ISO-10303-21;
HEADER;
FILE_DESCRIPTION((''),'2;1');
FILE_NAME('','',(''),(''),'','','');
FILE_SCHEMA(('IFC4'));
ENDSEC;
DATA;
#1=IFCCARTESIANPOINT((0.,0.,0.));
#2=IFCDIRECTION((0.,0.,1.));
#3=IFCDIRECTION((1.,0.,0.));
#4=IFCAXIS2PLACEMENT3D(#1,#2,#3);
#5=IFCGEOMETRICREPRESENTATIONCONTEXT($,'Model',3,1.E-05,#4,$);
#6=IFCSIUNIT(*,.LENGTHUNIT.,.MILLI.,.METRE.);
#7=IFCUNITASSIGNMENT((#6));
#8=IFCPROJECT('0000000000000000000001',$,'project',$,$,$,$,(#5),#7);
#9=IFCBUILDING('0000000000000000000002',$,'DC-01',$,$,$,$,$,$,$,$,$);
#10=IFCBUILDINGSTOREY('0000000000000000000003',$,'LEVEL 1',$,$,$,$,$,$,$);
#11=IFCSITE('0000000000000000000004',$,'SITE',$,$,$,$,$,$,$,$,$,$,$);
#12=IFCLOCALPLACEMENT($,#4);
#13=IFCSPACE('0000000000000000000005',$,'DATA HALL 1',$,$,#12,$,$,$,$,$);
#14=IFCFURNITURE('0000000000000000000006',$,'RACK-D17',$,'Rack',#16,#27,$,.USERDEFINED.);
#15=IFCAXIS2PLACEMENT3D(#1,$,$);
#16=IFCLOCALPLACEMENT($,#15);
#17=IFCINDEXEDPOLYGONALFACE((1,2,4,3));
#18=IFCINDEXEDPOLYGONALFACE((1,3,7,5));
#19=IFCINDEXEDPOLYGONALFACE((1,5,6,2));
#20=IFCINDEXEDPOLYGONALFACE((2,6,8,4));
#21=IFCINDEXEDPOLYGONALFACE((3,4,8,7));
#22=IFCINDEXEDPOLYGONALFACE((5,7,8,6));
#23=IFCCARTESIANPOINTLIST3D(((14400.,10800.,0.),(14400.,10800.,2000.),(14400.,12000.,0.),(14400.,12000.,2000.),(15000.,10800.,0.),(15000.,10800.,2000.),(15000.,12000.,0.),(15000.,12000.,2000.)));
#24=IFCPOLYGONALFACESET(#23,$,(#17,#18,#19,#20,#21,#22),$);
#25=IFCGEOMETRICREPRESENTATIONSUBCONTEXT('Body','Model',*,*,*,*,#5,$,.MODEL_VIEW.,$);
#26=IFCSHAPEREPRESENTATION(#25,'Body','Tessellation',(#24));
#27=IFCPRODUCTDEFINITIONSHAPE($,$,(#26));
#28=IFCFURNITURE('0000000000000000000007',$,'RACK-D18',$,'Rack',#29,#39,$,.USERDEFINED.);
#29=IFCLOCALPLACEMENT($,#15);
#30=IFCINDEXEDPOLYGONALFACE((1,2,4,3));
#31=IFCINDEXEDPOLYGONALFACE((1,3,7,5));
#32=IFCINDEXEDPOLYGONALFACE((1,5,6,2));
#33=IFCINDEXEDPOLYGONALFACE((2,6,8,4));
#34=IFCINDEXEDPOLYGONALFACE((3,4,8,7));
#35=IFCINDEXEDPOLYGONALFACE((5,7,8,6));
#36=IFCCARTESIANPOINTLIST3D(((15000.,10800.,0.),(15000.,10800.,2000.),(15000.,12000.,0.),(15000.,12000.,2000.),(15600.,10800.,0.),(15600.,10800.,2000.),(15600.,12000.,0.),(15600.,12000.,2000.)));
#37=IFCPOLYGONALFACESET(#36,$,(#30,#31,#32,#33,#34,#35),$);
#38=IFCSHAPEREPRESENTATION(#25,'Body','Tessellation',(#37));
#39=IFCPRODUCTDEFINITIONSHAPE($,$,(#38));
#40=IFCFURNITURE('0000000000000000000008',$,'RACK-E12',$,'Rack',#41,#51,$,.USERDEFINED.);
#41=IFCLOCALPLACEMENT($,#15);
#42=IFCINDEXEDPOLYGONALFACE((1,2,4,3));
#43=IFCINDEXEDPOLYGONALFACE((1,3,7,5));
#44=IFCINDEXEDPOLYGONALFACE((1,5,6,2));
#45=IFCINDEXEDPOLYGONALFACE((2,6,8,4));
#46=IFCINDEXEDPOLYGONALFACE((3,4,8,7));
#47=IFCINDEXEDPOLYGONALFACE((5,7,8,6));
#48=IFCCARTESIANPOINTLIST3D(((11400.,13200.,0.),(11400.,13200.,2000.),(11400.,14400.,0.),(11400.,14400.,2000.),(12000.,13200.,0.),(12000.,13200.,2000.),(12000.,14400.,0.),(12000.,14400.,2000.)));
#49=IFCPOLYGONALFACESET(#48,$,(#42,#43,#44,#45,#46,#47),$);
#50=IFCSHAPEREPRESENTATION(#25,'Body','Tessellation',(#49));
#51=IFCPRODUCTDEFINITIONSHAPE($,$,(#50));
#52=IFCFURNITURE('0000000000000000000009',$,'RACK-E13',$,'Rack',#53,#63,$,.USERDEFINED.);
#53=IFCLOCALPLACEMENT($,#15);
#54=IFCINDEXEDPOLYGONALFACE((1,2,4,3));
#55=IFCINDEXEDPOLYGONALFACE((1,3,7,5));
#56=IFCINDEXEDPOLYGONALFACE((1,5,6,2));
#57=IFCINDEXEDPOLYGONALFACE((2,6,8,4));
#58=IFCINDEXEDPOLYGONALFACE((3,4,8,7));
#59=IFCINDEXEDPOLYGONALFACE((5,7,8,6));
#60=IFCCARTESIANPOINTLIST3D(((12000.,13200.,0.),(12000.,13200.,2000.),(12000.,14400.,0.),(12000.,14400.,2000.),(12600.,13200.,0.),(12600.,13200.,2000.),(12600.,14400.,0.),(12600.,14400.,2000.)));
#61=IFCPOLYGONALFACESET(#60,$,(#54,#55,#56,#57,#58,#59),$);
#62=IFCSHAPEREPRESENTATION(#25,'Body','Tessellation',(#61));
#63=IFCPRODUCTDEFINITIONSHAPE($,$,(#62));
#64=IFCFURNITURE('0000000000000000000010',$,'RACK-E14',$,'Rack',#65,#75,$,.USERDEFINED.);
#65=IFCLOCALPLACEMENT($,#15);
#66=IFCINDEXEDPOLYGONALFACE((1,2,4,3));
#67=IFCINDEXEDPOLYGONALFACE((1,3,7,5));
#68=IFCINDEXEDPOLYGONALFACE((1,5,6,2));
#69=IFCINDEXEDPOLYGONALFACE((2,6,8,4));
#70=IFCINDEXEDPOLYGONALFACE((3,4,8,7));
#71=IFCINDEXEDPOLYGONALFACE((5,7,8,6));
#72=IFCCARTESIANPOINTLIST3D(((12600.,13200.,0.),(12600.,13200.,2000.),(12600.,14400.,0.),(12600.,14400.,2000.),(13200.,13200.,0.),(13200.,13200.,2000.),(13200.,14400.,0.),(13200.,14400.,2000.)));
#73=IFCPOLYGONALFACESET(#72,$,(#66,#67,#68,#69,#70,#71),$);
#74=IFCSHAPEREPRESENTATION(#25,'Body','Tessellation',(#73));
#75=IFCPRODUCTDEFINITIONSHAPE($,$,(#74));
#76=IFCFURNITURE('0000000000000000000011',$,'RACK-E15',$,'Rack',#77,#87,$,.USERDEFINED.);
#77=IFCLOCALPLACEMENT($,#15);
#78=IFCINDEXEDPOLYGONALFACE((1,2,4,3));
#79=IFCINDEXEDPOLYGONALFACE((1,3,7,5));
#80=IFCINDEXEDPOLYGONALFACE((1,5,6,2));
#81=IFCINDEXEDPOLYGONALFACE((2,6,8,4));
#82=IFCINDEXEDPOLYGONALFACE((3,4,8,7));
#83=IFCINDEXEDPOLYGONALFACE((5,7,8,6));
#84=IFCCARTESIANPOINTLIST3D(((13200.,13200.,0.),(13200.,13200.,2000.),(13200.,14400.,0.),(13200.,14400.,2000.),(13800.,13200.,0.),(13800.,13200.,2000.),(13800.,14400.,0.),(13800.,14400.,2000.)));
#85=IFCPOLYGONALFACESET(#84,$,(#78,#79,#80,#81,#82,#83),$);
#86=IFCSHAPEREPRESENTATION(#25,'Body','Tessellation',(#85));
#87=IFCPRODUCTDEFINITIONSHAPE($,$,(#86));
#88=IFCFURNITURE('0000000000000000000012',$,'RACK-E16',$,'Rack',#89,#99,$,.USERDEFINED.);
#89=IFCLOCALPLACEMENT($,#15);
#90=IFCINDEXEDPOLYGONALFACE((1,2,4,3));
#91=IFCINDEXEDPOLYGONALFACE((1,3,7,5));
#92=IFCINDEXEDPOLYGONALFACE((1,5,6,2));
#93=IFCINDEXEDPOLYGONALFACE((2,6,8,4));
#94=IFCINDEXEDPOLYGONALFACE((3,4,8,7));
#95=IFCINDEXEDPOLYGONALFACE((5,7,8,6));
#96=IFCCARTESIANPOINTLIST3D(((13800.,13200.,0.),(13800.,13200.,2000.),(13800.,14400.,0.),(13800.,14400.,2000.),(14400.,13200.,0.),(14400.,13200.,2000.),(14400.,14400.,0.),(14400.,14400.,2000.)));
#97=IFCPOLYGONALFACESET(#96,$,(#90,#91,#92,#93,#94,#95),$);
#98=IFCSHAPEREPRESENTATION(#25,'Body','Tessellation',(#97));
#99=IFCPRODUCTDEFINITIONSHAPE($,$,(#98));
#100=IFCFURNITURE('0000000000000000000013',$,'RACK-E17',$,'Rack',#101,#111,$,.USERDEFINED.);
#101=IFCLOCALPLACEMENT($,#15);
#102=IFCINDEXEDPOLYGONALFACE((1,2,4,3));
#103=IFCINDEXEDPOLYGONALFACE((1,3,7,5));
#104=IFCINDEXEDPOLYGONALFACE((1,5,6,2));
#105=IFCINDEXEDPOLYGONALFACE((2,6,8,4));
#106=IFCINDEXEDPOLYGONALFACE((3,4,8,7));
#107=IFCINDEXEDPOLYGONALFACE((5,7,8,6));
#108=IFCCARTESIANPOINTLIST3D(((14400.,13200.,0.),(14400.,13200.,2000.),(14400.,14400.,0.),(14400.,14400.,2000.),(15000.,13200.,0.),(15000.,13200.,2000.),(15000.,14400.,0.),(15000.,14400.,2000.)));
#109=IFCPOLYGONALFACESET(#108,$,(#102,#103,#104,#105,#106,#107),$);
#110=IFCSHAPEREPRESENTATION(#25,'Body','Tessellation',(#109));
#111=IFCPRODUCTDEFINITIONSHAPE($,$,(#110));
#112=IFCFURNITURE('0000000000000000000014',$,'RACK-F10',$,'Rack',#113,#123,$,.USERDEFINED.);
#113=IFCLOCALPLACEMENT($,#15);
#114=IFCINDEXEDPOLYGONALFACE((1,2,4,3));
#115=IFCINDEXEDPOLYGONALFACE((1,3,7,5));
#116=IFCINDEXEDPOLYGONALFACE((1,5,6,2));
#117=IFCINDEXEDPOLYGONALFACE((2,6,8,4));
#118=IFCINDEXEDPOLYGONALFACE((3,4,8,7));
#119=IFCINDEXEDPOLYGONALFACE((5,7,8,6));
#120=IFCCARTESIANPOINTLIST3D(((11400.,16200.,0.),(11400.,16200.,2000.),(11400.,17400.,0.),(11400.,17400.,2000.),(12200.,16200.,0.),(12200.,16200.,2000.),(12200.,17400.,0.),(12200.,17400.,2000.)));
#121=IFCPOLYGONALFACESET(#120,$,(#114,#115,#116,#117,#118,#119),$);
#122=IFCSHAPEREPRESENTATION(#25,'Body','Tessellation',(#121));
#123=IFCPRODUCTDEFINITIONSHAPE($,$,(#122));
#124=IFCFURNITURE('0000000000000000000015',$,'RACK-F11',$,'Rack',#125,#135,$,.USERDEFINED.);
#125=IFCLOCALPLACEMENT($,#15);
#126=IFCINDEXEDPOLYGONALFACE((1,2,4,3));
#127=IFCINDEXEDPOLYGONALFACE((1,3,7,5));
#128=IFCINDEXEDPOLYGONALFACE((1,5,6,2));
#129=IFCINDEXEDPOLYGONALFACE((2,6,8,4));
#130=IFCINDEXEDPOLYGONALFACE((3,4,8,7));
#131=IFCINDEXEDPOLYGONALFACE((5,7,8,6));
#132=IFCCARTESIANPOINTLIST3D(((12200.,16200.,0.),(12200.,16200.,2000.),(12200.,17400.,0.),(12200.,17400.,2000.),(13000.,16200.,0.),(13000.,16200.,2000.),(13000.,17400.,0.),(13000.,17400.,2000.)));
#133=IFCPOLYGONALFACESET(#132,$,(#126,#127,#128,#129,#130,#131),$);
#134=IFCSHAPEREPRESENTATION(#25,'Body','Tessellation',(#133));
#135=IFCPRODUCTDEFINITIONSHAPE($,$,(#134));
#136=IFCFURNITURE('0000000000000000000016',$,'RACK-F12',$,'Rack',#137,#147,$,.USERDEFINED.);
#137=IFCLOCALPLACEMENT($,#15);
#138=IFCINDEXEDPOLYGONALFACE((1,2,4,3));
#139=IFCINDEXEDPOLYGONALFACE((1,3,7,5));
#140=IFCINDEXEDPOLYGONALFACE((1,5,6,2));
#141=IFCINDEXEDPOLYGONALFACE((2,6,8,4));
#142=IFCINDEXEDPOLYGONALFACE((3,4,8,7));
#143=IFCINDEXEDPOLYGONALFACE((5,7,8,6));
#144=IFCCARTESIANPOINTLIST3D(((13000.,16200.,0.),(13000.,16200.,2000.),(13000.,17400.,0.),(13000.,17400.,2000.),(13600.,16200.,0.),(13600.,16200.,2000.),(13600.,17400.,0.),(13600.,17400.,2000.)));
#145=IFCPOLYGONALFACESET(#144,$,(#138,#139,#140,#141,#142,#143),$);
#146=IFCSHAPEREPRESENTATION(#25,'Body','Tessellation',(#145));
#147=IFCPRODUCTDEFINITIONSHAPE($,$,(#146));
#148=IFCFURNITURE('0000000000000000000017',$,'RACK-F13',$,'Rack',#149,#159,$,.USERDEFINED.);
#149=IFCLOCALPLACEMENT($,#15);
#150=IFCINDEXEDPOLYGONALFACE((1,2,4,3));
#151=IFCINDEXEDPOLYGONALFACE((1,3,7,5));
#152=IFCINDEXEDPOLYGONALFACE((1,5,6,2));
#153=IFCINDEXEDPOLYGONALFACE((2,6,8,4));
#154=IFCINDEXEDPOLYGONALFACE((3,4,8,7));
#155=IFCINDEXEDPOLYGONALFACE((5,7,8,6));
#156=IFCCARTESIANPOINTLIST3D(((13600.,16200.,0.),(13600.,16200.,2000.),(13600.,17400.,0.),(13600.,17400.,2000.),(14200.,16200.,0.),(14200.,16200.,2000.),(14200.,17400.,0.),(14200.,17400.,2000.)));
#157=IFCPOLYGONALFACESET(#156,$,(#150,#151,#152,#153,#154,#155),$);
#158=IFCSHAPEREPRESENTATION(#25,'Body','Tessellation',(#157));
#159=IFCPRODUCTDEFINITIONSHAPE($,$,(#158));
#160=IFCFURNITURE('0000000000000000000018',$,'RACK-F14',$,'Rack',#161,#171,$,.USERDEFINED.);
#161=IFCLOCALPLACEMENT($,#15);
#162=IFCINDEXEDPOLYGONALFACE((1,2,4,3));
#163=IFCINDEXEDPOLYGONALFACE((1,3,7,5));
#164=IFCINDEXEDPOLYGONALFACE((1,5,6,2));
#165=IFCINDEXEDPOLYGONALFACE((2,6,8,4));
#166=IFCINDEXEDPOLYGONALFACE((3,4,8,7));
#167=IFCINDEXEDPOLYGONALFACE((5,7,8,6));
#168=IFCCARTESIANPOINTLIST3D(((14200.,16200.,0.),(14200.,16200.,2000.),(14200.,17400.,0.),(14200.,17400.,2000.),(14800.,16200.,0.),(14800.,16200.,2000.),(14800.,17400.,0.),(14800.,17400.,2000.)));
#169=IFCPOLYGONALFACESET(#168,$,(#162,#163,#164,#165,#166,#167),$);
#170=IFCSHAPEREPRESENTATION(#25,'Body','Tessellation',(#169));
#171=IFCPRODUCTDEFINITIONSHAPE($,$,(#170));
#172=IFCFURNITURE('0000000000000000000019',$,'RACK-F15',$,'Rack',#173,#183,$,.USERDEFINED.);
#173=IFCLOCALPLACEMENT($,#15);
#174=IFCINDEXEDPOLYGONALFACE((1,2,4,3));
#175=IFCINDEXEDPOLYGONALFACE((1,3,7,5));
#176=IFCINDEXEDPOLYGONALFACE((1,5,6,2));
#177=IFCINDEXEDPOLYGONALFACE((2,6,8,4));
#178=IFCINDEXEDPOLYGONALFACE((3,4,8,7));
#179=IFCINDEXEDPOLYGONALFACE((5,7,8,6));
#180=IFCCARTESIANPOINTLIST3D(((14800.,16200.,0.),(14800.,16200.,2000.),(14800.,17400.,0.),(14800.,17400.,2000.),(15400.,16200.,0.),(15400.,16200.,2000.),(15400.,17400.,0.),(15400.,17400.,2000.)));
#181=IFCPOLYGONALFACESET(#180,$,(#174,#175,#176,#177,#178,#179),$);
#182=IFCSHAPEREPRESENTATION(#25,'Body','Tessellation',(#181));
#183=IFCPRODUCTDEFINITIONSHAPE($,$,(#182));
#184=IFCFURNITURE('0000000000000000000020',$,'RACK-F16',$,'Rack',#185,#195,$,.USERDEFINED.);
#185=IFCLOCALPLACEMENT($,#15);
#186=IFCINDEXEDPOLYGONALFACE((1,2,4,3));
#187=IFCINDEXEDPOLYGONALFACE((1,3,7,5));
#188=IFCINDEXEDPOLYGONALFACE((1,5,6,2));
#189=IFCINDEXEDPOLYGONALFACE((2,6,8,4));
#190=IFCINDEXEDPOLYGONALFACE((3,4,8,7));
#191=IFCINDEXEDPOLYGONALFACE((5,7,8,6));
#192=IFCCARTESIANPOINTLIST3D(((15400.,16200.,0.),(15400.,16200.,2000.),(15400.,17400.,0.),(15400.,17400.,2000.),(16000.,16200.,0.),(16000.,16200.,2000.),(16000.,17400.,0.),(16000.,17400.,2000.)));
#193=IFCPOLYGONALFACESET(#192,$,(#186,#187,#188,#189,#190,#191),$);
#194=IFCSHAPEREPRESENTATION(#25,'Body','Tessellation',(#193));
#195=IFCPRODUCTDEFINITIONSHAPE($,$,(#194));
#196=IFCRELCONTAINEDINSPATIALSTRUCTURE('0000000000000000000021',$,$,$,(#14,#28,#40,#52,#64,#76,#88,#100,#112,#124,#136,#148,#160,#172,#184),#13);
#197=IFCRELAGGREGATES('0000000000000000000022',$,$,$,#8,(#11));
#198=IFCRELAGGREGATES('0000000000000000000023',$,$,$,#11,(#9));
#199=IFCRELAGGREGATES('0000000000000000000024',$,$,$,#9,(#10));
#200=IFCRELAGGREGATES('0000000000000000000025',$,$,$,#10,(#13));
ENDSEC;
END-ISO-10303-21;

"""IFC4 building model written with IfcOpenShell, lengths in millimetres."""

from ifc_helpers import new_model, si_unit, frame, origin, origin_with_axes, place, context, subcontext, project, spatial, polyline, outline, extrude, element, save


model = new_model("IFC4")

# Units and contexts
model_context = context("Model", 3, precision=1e-05, world=origin_with_axes())
body_context = subcontext(model_context, "Body", "Model", "MODEL_VIEW")
ifc_project = project(units=[si_unit("LENGTHUNIT", "METRE", prefix="MILLI")], contexts=[model_context])

# Site, building, storey, space
site = spatial("IfcSite", under=ifc_project, Name="SITE")
building = spatial("IfcBuilding", under=site, Name="DC-01")
storey = spatial("IfcBuildingStorey", under=building, Name="LEVEL 1")
space_placement = place(None, origin_with_axes())
space = spatial("IfcSpace", under=storey, at=space_placement, Name="DATA HALL 1")

# Furniture
for number, where, z_axis, x_axis, name in (
    (1, (14400.0, 10800.0, 0.0), (0.0, 0.0, 1.0), (1.0, 0.0, 0.0), "RACK-D17"),
    (2, (15000.0, 10800.0, 0.0), (0.0, 0.0, 1.0), (1.0, 0.0, 0.0), "RACK-D18"),
    (3, (12000.0, 14400.0, 0.0), (0.0, 0.0, 1.0), (-1.0, 0.0, 0.0), "RACK-E12"),
    (4, (12600.0, 14400.0, 0.0), (0.0, 0.0, 1.0), (-1.0, 0.0, 0.0), "RACK-E13"),
    (5, (13200.0, 14400.0, 0.0), (0.0, 0.0, 1.0), (-1.0, 0.0, 0.0), "RACK-E14"),
    (6, (13800.0, 14400.0, 0.0), (0.0, 0.0, 1.0), (-1.0, 0.0, 0.0), "RACK-E15"),
    (7, (14400.0, 14400.0, 0.0), (0.0, 0.0, 1.0), (-1.0, 0.0, 0.0), "RACK-E16"),
    (8, (15000.0, 14400.0, 0.0), (0.0, 0.0, 1.0), (-1.0, 0.0, 0.0), "RACK-E17"),
):
    element("IfcFurniture", number, at=place(space_placement, frame(where, z_axis=z_axis, x_axis=x_axis)), inside=space, Name=name, ObjectType="Rack", PredefinedType="USERDEFINED", context=body_context, shape_type="SweptSolid", body=[
        extrude(outline(polyline([(0.0, 0.0), (600.0, 0.0), (600.0, 1200.0), (0.0, 1200.0), (0.0, 0.0)])), origin(), (0.0, 0.0, 1.0), 2000.0),
    ])
for number, where, z_axis, x_axis, name in (
    (9, (11400.0, 16200.0, 0.0), (0.0, 0.0, 1.0), (1.0, 0.0, 0.0), "RACK-F10"),
    (10, (12200.0, 16200.0, 0.0), (0.0, 0.0, 1.0), (1.0, 0.0, 0.0), "RACK-F11"),
):
    element("IfcFurniture", number, at=place(space_placement, frame(where, z_axis=z_axis, x_axis=x_axis)), inside=space, Name=name, ObjectType="Rack", PredefinedType="USERDEFINED", context=body_context, shape_type="SweptSolid", body=[
        extrude(outline(polyline([(0.0, 0.0), (800.0, 0.0), (800.0, 1200.0), (0.0, 1200.0), (0.0, 0.0)])), origin(), (0.0, 0.0, 1.0), 2000.0),
    ])
for number, where, z_axis, x_axis, name in (
    (11, (13000.0, 16200.0, 0.0), (0.0, 0.0, 1.0), (1.0, 0.0, 0.0), "RACK-F12"),
    (12, (13600.0, 16200.0, 0.0), (0.0, 0.0, 1.0), (1.0, 0.0, 0.0), "RACK-F13"),
    (13, (14200.0, 16200.0, 0.0), (0.0, 0.0, 1.0), (1.0, 0.0, 0.0), "RACK-F14"),
    (14, (14800.0, 16200.0, 0.0), (0.0, 0.0, 1.0), (1.0, 0.0, 0.0), "RACK-F15"),
    (15, (15400.0, 16200.0, 0.0), (0.0, 0.0, 1.0), (1.0, 0.0, 0.0), "RACK-F16"),
):
    element("IfcFurniture", number, at=place(space_placement, frame(where, z_axis=z_axis, x_axis=x_axis)), inside=space, Name=name, ObjectType="Rack", PredefinedType="USERDEFINED", context=body_context, shape_type="SweptSolid", body=[
        extrude(outline(polyline([(0.0, 0.0), (600.0, 0.0), (600.0, 1200.0), (0.0, 1200.0), (0.0, 0.0)])), origin(), (0.0, 0.0, 1.0), 2000.0),
    ])

save(model, "model.ifc")
